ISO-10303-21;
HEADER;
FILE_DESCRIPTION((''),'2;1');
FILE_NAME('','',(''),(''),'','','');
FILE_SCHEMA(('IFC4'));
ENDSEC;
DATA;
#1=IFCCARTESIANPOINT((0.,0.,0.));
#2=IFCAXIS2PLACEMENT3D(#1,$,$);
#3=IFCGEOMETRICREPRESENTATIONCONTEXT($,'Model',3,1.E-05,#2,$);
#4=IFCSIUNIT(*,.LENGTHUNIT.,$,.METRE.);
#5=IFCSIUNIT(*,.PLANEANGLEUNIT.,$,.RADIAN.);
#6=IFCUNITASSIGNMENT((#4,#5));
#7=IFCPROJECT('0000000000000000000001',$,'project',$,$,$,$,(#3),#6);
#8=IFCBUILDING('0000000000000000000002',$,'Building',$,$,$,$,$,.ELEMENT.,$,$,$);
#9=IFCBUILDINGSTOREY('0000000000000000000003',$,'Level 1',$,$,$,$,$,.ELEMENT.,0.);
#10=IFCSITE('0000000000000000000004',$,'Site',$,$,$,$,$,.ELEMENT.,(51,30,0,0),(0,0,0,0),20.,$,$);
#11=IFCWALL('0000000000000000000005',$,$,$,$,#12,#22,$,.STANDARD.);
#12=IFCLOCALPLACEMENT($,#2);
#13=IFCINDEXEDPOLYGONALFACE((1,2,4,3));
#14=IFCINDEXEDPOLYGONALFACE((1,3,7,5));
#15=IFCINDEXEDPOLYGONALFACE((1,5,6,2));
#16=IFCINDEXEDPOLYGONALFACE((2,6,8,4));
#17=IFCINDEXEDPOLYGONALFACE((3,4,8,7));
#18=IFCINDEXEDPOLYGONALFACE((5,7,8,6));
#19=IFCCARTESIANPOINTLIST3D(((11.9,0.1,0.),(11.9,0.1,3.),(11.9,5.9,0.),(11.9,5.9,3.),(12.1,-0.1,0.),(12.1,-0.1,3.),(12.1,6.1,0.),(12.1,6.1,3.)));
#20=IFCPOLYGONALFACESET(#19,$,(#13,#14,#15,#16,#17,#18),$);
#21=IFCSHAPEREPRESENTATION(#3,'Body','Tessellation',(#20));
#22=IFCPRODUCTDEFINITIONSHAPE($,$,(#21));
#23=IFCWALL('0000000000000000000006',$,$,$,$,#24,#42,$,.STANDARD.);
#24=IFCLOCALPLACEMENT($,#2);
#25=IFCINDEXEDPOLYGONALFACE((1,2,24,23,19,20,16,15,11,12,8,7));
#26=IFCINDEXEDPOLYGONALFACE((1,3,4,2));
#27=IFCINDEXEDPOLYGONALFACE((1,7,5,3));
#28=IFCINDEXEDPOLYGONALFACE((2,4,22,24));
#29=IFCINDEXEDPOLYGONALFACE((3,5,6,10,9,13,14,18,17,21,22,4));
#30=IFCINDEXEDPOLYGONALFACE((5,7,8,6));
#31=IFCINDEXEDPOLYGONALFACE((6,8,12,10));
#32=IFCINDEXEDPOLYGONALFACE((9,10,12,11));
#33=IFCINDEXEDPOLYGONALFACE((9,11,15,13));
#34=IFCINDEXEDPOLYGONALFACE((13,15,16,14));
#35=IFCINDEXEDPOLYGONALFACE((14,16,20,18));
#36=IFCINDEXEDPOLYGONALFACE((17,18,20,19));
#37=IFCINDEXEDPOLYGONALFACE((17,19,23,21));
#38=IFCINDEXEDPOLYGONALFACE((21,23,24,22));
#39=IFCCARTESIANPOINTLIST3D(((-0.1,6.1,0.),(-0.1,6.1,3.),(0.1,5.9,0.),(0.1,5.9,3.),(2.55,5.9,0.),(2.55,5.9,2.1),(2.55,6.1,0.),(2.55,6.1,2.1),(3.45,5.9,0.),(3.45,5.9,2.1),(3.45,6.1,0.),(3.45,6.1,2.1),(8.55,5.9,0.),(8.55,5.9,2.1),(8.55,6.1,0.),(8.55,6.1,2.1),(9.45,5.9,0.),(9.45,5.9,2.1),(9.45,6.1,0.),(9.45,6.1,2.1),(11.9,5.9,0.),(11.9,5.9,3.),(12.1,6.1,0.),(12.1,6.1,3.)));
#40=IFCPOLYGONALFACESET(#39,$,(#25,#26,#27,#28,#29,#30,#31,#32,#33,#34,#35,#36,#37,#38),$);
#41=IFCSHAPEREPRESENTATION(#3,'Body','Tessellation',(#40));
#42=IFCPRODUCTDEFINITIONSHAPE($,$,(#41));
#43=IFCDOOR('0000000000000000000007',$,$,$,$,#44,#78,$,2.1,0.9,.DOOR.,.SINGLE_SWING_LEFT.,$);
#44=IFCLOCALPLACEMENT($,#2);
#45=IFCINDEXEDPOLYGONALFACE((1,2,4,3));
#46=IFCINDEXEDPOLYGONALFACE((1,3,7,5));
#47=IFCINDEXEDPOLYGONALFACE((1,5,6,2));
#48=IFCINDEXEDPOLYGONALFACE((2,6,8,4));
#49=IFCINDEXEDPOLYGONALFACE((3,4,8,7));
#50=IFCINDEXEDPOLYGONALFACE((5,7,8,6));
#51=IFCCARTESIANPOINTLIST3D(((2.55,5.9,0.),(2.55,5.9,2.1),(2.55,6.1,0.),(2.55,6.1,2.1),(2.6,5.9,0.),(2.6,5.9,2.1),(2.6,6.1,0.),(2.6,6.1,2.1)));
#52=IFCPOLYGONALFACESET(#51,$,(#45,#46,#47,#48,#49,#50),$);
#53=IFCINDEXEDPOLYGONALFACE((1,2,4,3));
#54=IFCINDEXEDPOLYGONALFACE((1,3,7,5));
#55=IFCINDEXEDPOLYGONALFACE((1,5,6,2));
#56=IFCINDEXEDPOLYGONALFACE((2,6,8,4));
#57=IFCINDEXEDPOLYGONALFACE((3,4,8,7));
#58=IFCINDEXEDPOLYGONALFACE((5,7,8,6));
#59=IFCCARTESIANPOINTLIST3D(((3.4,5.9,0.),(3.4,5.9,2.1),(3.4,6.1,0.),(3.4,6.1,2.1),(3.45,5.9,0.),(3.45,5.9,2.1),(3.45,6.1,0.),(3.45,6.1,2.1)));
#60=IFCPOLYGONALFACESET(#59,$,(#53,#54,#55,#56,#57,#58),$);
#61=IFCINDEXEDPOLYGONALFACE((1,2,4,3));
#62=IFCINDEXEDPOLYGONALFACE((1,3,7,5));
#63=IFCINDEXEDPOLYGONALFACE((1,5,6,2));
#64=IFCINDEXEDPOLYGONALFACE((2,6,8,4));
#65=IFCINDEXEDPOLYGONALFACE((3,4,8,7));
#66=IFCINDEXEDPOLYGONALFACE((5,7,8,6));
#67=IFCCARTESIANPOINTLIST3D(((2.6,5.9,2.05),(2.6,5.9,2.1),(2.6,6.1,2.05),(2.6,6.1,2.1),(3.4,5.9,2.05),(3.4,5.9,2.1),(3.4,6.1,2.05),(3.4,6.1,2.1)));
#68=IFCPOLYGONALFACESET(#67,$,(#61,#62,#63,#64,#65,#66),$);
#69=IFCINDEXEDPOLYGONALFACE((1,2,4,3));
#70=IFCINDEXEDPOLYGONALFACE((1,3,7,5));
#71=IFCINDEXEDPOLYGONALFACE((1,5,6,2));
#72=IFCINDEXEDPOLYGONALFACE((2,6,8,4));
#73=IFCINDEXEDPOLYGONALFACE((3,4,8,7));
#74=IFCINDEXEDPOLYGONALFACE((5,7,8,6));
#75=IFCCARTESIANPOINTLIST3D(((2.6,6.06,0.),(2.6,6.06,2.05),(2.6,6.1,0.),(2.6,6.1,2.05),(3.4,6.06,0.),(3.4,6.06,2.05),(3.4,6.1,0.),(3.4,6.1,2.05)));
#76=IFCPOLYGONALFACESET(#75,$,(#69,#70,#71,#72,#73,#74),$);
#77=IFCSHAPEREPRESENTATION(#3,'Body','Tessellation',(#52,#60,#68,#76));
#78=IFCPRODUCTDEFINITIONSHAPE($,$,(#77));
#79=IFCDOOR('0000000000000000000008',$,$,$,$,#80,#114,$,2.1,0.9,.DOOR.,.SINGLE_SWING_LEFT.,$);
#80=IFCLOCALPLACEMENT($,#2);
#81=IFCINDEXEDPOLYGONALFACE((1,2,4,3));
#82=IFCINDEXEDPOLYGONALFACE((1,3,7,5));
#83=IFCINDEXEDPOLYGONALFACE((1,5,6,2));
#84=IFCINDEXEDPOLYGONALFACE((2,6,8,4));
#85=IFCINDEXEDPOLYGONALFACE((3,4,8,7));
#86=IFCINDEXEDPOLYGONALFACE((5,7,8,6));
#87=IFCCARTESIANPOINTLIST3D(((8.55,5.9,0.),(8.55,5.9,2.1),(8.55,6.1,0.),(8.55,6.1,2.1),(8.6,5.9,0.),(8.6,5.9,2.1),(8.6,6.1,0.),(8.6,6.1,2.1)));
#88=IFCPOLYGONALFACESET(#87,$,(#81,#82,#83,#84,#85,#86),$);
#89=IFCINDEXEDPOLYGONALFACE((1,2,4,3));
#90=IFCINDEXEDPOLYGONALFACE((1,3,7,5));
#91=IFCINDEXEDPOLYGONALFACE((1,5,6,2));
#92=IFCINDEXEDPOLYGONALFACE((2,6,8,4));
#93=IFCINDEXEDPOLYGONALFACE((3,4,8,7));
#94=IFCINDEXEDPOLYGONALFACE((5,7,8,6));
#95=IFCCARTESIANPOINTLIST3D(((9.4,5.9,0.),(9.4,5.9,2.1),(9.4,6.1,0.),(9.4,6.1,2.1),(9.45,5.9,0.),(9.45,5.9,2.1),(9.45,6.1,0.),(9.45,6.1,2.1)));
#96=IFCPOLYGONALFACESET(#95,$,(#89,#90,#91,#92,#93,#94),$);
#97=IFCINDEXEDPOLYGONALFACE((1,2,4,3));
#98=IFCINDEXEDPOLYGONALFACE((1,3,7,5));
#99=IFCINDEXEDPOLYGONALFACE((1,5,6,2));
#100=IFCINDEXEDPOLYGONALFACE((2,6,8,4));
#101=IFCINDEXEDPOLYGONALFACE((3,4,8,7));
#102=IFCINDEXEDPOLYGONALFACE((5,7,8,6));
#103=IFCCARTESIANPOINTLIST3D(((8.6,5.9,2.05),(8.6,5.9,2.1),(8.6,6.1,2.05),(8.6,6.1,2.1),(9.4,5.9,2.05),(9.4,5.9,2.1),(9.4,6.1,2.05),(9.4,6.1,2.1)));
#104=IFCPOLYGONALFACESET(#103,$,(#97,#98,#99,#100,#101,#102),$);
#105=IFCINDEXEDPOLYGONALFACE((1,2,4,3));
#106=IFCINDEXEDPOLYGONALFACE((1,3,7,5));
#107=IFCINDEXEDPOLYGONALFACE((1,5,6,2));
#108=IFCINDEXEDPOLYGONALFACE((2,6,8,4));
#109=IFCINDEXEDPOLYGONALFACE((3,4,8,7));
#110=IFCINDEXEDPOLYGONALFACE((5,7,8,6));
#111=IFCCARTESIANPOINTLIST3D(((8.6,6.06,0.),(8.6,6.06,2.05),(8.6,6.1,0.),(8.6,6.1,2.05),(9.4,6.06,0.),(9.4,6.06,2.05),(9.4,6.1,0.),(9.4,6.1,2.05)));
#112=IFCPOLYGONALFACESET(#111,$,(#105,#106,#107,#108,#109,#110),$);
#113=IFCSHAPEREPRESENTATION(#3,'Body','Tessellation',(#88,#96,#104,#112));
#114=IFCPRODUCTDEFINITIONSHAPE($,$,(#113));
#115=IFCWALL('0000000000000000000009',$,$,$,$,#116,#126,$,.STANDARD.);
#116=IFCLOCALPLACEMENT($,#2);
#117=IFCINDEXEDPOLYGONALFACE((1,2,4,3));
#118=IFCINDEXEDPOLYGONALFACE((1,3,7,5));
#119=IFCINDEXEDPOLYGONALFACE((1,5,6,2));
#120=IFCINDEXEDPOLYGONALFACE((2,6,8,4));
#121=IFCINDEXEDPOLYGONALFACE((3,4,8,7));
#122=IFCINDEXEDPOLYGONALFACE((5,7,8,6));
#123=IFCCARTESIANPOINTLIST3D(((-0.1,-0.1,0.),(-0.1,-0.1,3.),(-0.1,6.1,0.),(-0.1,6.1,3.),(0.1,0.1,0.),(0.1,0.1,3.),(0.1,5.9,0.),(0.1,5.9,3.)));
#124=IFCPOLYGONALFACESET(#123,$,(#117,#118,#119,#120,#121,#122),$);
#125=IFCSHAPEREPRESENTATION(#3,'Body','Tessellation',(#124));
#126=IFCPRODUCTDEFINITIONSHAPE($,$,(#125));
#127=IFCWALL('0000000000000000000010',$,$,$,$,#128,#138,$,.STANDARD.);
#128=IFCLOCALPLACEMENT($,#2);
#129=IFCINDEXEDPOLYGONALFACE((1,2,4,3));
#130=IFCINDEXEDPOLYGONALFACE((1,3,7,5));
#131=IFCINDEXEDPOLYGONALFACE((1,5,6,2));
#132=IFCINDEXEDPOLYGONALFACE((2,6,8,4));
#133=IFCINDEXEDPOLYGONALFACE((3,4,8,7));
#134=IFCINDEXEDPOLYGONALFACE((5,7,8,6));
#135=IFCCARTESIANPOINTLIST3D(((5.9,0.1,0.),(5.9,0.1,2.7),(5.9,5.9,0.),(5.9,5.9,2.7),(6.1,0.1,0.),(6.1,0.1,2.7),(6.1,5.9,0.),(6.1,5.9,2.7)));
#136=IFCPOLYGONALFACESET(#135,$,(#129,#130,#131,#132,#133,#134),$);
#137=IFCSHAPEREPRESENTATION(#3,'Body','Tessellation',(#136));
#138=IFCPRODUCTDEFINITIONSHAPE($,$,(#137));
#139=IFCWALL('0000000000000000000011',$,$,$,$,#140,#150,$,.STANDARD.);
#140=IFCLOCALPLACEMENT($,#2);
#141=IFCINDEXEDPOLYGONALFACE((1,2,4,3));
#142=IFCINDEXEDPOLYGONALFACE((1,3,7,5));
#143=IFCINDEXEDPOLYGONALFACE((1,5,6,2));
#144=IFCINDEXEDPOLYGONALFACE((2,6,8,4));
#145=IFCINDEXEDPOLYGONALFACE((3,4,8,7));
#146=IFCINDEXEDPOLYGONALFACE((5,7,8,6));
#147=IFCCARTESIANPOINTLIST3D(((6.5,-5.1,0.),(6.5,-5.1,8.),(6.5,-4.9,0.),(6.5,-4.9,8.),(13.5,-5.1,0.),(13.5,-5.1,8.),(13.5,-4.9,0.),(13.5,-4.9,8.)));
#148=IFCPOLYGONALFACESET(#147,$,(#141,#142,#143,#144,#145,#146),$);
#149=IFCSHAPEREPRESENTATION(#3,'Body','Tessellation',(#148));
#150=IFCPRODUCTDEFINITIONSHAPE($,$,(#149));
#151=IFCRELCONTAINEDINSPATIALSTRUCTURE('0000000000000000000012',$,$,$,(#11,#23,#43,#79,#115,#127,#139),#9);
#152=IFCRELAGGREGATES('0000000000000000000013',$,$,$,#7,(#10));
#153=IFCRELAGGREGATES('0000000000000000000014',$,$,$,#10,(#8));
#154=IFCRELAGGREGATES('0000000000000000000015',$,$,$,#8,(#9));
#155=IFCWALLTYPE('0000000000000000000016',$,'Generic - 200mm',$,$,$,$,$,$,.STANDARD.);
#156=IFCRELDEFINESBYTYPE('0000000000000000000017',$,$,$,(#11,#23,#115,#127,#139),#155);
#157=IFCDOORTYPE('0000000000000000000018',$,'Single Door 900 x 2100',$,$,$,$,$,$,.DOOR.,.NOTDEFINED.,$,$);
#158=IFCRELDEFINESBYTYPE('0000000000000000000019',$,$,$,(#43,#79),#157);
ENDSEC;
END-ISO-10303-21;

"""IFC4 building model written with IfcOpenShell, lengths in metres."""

from ifc_helpers import new_model, si_unit, frame, frame_2d, origin, origin_with_axes, origin_2d, place, context, project, spatial, polyline, rectangle, outline, extrude, type_object, element, fill, save


model = new_model("IFC4")

# Units and contexts
model_context = context("Model", 3, precision=1e-05, world=origin())
ifc_project = project(units=[si_unit("LENGTHUNIT", "METRE"), si_unit("PLANEANGLEUNIT", "RADIAN")], contexts=[model_context])

# Site, building, storey
site = spatial("IfcSite", under=ifc_project, Name="Site", CompositionType="ELEMENT", RefLatitude=(51, 30, 0, 0), RefLongitude=(0, 0, 0, 0), RefElevation=20.0)
building = spatial("IfcBuilding", under=site, Name="Building", CompositionType="ELEMENT")
storey = spatial("IfcBuildingStorey", under=building, Name="Level 1", CompositionType="ELEMENT", Elevation=0.0)

# Shared definitions
wall_type = type_object("IfcWallType", Name="Generic - 200mm", PredefinedType="STANDARD")

# Wall
wall_1_placement = place(None, frame((12.0, 6.0, 0.0), z_axis=(0.0, 0.0, 1.0), x_axis=(0.0, -1.0, 0.0)))
element("IfcWall", 1, at=wall_1_placement, inside=storey, type_object=wall_type, PredefinedType="STANDARD", context=model_context, shape_type="SweptSolid", body=[
    extrude(outline(polyline([(0.1, -0.1), (5.9, -0.1), (6.1, 0.1), (-0.1, 0.1), (0.1, -0.1)])), origin(), (0.0, 0.0, 1.0), 3.0),
])

# Wall, openings, doors
wall_2_placement = place(None, frame((0.0, 6.0, 0.0), z_axis=(0.0, 0.0, 1.0), x_axis=(1.0, 0.0, 0.0)))
wall_2 = element("IfcWall", 2, at=wall_2_placement, inside=storey, type_object=wall_type, PredefinedType="STANDARD", context=model_context, shape_type="SweptSolid", body=[
    extrude(outline(polyline([(0.1, -0.1), (11.9, -0.1), (12.1, 0.1), (-0.1, 0.1), (0.1, -0.1)])), origin(), (0.0, 0.0, 1.0), 3.0),
])
opening_1_placement = place(wall_2_placement, frame((3.0, 0.0, 0.0), z_axis=(0.0, 0.0, 1.0), x_axis=(1.0, 0.0, 0.0)))
opening_1 = element("IfcOpeningElement", 3, at=opening_1_placement, cuts=wall_2, PredefinedType="OPENING", context=model_context, shape_type="SweptSolid", body=[
    extrude(rectangle(XDim=0.9, YDim=0.202, at=origin_2d()), origin(), (0.0, 0.0, 1.0), 2.1),
])
opening_2_placement = place(wall_2_placement, frame((9.0, 0.0, 0.0), z_axis=(0.0, 0.0, 1.0), x_axis=(1.0, 0.0, 0.0)))
opening_2 = element("IfcOpeningElement", 4, at=opening_2_placement, cuts=wall_2, PredefinedType="OPENING", context=model_context, shape_type="SweptSolid", body=[
    extrude(rectangle(XDim=0.9, YDim=0.202, at=origin_2d()), origin(), (0.0, 0.0, 1.0), 2.1),
])
door_type = type_object("IfcDoorType", Name="Single Door 900 x 2100", OperationType="NOTDEFINED", PredefinedType="DOOR")
door_1_placement = place(opening_1_placement, origin_with_axes())
door_1 = element("IfcDoor", 5, at=door_1_placement, inside=storey, type_object=door_type, OperationType="SINGLE_SWING_LEFT", OverallHeight=2.1, OverallWidth=0.9, PredefinedType="DOOR", context=model_context, shape_type="SweptSolid", body=[
    extrude(rectangle(XDim=0.05, YDim=0.2, at=frame_2d((-0.425, 0.0))), origin(), (0.0, 0.0, 1.0), 2.1),
    extrude(rectangle(XDim=0.05, YDim=0.2, at=frame_2d((0.425, 0.0))), origin(), (0.0, 0.0, 1.0), 2.1),
    extrude(rectangle(XDim=0.8, YDim=0.2, at=origin_2d()), frame((0.0, 0.0, 2.05)), (0.0, 0.0, 1.0), 0.05),
    extrude(rectangle(XDim=0.8, YDim=0.04, at=frame_2d((0.0, 0.08))), origin(), (0.0, 0.0, 1.0), 2.05),
])
fill(opening_1, door_1)
door_2_placement = place(opening_2_placement, origin_with_axes())
door_2 = element("IfcDoor", 6, at=door_2_placement, inside=storey, type_object=door_type, OperationType="SINGLE_SWING_LEFT", OverallHeight=2.1, OverallWidth=0.9, PredefinedType="DOOR", context=model_context, shape_type="SweptSolid", body=[
    extrude(rectangle(XDim=0.05, YDim=0.2, at=frame_2d((-0.425, 0.0))), origin(), (0.0, 0.0, 1.0), 2.1),
    extrude(rectangle(XDim=0.05, YDim=0.2, at=frame_2d((0.425, 0.0))), origin(), (0.0, 0.0, 1.0), 2.1),
    extrude(rectangle(XDim=0.8, YDim=0.2, at=origin_2d()), frame((0.0, 0.0, 2.05)), (0.0, 0.0, 1.0), 0.05),
    extrude(rectangle(XDim=0.8, YDim=0.04, at=frame_2d((0.0, 0.08))), origin(), (0.0, 0.0, 1.0), 2.05),
])
fill(opening_2, door_2)

# Walls
wall_3_placement = place(None, frame((0.0, 0.0, 0.0), z_axis=(0.0, 0.0, 1.0), x_axis=(0.0, 1.0, 0.0)))
element("IfcWall", 7, at=wall_3_placement, inside=storey, type_object=wall_type, PredefinedType="STANDARD", context=model_context, shape_type="SweptSolid", body=[
    extrude(outline(polyline([(0.1, -0.1), (5.9, -0.1), (6.1, 0.1), (-0.1, 0.1), (0.1, -0.1)])), origin(), (0.0, 0.0, 1.0), 3.0),
])
wall_4_placement = place(None, frame((6.0, 0.0, 0.0), z_axis=(0.0, 0.0, 1.0), x_axis=(0.0, 1.0, 0.0)))
element("IfcWall", 8, at=wall_4_placement, inside=storey, type_object=wall_type, PredefinedType="STANDARD", context=model_context, shape_type="SweptSolid", body=[
    extrude(outline(polyline([(0.1, -0.1), (5.9, -0.1), (5.9, 0.1), (0.1, 0.1), (0.1, -0.1)])), origin(), (0.0, 0.0, 1.0), 2.7),
])
wall_5_placement = place(None, frame((13.5, -5.0, 0.0), z_axis=(0.0, 0.0, 1.0), x_axis=(-1.0, 0.0, 0.0)))
element("IfcWall", 9, at=wall_5_placement, inside=storey, type_object=wall_type, PredefinedType="STANDARD", context=model_context, shape_type="SweptSolid", body=[
    extrude(rectangle(XDim=7.0, YDim=0.2, at=frame_2d((3.5, 0.0))), origin(), (0.0, 0.0, 1.0), 8.0),
])

save(model, "model.ifc")
